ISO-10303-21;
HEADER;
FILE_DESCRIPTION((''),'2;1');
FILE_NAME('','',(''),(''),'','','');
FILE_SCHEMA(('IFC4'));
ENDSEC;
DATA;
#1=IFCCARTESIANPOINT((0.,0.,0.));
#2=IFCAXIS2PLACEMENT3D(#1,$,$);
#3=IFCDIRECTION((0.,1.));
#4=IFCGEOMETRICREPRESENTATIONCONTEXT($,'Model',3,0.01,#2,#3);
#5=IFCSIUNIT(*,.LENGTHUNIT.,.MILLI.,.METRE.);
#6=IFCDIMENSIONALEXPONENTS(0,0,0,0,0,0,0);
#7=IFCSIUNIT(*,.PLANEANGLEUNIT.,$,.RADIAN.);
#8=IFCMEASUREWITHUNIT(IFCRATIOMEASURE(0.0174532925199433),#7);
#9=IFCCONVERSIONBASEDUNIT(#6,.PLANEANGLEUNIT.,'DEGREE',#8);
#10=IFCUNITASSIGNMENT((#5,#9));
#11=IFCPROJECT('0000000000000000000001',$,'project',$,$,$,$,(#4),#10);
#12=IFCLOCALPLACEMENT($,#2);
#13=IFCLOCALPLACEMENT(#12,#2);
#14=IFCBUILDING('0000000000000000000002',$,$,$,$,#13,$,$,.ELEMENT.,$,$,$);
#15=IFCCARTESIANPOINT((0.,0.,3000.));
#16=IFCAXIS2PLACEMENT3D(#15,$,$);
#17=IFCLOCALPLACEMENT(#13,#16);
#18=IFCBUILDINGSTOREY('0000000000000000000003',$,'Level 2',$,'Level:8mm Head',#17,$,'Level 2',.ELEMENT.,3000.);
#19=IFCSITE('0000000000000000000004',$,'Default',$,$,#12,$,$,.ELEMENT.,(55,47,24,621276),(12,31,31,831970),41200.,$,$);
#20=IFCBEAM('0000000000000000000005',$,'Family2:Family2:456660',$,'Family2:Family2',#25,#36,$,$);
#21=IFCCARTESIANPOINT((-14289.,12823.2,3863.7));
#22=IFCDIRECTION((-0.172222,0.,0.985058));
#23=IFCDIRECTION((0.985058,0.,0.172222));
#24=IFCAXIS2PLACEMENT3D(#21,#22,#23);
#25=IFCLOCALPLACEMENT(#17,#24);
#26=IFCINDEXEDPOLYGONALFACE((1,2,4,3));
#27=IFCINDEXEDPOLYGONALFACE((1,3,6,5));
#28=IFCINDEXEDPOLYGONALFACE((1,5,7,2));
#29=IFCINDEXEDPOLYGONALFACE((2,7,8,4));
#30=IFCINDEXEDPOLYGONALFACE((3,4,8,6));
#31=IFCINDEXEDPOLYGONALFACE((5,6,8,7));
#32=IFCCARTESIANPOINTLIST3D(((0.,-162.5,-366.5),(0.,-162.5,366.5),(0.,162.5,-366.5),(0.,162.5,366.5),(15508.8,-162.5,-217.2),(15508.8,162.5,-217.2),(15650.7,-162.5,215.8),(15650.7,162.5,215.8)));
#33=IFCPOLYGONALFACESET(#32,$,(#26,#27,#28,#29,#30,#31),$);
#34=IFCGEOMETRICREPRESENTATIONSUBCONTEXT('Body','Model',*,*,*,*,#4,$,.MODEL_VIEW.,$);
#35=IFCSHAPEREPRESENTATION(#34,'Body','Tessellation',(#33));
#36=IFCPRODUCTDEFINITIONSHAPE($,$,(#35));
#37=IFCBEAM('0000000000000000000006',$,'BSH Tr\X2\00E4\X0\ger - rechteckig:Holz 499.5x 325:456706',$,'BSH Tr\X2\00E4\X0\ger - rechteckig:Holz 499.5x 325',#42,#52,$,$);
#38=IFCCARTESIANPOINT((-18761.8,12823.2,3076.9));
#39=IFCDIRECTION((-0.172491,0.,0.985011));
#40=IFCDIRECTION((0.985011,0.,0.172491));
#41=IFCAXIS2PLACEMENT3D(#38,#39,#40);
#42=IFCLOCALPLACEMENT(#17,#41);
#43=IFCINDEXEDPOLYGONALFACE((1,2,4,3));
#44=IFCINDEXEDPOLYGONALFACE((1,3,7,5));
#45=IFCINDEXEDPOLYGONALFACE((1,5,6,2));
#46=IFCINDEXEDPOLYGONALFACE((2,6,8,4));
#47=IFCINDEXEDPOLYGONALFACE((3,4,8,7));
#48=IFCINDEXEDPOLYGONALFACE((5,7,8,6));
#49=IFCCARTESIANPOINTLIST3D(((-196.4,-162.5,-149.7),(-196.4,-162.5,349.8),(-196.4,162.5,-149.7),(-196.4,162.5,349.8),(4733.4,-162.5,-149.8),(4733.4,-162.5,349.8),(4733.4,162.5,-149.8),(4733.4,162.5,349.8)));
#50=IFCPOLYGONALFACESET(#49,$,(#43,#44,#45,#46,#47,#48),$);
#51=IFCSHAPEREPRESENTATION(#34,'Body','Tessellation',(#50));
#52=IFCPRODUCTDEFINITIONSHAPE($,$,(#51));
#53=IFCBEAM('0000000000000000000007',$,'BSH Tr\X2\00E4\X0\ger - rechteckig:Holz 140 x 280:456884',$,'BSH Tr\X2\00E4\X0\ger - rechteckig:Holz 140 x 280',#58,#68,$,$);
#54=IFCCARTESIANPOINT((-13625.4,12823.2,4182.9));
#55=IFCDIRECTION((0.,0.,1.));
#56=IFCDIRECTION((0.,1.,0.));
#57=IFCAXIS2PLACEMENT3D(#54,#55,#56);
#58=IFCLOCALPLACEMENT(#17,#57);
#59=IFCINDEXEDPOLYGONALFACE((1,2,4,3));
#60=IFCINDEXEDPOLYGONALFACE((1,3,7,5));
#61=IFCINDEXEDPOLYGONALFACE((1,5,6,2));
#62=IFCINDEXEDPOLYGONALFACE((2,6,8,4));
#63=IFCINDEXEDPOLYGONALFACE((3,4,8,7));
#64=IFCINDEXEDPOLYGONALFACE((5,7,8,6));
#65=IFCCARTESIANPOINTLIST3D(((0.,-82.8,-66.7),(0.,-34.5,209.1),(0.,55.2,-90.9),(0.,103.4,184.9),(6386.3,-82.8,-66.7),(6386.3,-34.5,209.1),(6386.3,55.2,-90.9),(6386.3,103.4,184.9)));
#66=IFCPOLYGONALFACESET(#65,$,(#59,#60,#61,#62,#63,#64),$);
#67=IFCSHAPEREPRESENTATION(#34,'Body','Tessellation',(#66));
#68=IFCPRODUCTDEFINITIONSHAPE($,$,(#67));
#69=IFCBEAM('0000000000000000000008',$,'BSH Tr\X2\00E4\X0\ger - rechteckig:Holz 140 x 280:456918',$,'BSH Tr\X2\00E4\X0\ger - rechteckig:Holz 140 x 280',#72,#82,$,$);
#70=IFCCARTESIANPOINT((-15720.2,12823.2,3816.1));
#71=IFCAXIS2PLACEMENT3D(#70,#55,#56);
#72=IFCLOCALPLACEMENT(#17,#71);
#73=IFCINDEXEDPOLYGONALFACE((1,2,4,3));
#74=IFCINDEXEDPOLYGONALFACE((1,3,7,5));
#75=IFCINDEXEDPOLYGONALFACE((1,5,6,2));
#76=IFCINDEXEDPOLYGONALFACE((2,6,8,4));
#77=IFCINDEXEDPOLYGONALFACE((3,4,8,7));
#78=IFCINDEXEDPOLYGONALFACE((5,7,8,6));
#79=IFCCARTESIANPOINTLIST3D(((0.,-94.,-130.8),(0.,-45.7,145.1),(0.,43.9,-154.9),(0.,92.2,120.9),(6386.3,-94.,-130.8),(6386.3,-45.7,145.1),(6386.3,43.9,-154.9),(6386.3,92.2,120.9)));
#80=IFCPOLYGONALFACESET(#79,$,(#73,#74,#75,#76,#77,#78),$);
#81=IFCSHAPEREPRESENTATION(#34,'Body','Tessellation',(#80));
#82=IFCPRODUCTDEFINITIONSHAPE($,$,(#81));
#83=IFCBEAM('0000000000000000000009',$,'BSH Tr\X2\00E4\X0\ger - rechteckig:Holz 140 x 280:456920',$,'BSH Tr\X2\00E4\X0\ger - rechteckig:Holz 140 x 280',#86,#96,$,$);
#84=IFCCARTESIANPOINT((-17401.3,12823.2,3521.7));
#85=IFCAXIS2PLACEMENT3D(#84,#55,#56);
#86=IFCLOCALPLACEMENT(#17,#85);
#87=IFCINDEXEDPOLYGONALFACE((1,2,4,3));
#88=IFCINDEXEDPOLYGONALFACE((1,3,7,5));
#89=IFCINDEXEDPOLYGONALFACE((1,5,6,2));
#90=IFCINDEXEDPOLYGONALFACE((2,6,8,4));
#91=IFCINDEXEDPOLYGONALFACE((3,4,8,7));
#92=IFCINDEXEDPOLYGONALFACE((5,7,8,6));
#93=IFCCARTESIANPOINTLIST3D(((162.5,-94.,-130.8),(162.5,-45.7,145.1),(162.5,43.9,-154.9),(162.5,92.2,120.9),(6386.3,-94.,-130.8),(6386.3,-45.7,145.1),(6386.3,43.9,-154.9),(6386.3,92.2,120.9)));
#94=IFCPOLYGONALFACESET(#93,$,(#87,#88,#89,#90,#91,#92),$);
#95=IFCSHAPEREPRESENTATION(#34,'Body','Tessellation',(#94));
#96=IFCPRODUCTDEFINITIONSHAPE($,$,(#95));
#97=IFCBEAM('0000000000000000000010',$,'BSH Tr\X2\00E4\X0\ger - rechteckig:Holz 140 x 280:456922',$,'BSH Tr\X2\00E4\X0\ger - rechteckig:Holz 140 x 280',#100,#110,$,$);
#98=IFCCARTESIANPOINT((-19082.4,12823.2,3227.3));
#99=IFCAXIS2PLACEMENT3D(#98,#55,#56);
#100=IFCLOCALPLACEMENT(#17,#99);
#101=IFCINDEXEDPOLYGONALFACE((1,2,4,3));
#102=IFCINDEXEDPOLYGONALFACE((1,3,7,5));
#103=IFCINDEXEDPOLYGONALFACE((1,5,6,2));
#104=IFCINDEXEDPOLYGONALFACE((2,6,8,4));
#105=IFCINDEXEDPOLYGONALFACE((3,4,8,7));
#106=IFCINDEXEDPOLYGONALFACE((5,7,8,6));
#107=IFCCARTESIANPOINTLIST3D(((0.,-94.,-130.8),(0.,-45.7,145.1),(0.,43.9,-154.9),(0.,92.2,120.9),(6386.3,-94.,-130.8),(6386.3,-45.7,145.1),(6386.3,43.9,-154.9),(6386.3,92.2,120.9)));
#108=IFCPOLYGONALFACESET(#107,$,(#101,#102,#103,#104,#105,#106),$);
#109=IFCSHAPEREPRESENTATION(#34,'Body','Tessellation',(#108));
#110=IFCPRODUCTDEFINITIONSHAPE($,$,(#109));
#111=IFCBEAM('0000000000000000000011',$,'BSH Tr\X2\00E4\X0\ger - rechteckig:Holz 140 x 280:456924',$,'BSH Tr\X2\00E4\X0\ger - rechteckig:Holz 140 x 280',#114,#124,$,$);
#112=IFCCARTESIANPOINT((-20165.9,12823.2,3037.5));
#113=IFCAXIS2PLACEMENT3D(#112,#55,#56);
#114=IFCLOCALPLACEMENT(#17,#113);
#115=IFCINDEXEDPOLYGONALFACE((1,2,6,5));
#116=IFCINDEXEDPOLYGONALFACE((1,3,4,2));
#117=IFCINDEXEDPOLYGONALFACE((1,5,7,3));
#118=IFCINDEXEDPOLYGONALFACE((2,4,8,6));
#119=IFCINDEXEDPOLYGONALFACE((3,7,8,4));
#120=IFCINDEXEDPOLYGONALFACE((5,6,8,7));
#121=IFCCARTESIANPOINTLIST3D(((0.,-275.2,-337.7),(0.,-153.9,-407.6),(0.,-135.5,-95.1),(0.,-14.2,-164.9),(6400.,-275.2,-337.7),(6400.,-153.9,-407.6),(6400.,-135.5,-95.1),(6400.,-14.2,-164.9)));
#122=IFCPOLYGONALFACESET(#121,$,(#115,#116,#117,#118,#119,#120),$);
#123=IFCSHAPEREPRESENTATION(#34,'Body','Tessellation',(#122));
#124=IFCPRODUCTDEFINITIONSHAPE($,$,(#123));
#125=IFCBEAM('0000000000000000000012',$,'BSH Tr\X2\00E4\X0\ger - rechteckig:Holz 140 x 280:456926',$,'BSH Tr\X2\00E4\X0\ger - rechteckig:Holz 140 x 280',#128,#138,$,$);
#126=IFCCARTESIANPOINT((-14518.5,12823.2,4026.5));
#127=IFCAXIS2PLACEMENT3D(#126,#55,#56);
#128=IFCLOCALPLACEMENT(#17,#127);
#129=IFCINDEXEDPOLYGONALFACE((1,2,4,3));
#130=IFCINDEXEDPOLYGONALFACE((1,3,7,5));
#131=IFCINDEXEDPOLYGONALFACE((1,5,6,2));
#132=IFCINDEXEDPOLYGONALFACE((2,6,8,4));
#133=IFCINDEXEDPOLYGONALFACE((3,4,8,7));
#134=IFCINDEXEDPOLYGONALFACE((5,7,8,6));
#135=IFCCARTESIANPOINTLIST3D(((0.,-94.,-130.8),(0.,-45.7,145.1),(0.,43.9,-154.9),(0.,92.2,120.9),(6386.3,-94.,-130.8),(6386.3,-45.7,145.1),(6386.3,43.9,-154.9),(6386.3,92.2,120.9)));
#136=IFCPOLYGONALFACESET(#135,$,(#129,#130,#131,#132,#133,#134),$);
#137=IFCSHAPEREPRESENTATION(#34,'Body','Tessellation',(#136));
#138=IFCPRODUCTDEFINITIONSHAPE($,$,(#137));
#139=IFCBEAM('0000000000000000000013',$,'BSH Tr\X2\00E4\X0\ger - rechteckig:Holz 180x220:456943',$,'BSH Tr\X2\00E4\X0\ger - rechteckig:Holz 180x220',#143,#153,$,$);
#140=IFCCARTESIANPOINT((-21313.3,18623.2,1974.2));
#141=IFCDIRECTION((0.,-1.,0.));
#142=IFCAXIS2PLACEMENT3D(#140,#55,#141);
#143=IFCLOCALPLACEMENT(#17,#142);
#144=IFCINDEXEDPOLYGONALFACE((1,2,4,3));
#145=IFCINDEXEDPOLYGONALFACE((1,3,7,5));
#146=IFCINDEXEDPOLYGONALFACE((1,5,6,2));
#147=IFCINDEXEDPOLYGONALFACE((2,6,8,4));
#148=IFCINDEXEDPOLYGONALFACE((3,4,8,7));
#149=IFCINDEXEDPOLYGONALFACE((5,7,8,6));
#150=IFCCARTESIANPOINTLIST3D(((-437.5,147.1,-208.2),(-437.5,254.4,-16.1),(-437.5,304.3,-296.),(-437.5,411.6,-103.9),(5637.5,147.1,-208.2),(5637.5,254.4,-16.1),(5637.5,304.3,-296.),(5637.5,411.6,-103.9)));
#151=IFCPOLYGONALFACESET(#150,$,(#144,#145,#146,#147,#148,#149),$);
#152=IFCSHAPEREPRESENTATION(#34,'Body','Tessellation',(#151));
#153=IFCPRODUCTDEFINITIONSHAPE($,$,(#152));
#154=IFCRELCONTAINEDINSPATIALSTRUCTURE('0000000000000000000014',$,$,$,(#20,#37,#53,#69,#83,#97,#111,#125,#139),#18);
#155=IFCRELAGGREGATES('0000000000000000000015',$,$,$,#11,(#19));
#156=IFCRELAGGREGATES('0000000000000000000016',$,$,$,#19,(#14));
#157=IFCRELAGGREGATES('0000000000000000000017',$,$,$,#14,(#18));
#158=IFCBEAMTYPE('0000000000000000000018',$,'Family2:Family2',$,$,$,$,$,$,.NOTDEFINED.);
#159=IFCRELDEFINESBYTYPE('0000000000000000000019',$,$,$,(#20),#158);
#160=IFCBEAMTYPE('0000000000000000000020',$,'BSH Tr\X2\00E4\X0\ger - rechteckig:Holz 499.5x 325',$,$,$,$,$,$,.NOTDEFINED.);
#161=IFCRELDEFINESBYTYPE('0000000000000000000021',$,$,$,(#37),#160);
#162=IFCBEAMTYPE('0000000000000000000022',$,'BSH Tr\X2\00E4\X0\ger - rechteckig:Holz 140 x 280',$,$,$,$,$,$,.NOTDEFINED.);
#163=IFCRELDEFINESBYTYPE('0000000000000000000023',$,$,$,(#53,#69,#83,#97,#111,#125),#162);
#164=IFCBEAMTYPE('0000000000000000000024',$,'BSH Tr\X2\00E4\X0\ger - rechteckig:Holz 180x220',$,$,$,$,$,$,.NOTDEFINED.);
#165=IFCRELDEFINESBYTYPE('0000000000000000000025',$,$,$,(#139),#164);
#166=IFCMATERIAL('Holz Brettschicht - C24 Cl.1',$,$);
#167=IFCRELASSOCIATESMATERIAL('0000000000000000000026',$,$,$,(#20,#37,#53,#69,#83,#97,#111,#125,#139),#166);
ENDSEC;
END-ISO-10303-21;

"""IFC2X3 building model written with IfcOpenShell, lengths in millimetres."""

from ifc_helpers import new_model, entity, si_unit, converted_unit, direction, frame, frame_2d, origin, origin_2d_with_axis, place, context, subcontext, project, spatial, polyline, rectangle, extrude, clip, bounded_halfspace, material, type_object, element, save


model = new_model("IFC2X3")

# Units and contexts
model_context = context("Model", 3, precision=0.01, world=origin(), true_north=direction((0.0, 1.0)))
body_context = subcontext(model_context, "Body", "Model", "MODEL_VIEW")
ifc_project = project(units=[si_unit("LENGTHUNIT", "METRE", prefix="MILLI"), converted_unit("PLANEANGLEUNIT", "DEGREE", entity("IfcRatioMeasure", 0.0174532925199433), si_unit("PLANEANGLEUNIT", "RADIAN"), dimensions=[0, 0, 0, 0, 0, 0, 0])], contexts=[model_context])

# Site, building, storey
site_placement = place(None, origin())
site = spatial("IfcSite", under=ifc_project, at=site_placement, Name="Default", CompositionType="ELEMENT", RefLatitude=(55, 47, 24, 621276), RefLongitude=(12, 31, 31, 831970), RefElevation=41200.0)
building_placement = place(site_placement, origin())
building = spatial("IfcBuilding", under=site, at=building_placement, CompositionType="ELEMENT")
storey_placement = place(building_placement, frame((0.0, 0.0, 3000.0)))
storey = spatial("IfcBuildingStorey", under=building, at=storey_placement, Name="Level 2", ObjectType="Level:8mm Head", LongName="Level 2", CompositionType="ELEMENT", Elevation=3000.0)

# Beams
ifc_material = material(Name="Holz Brettschicht - C24 Cl.1")
beam_type_1 = type_object("IfcBeamType", Name="Family2:Family2", PredefinedType="NOTDEFINED")
beam_1_placement = place(storey_placement, frame((-14289.0, 12823.2, 3863.7), z_axis=(-0.172222, 0.0, 0.985058), x_axis=(0.985058, 0.0, 0.172222)))
element("IfcBeam", 1, at=beam_1_placement, inside=storey, type_object=beam_type_1, material=ifc_material, Name="Family2:Family2:456660", ObjectType="Family2:Family2", context=body_context, shape_type="Clipping", body=[
    clip(clip(clip(extrude(rectangle(XDim=733.0, YDim=325.0, at=frame_2d((0.0, 0.0), x_axis=(0.0, 1.0))), frame((0.0, 0.0, 0.0), z_axis=(1.0, 0.0, 0.0), x_axis=(0.0, 1.0, 0.0)), (0.0, 0.0, 1.0), 15650.7), bounded_halfspace(frame((0.0, 0.0, -366.5), z_axis=(0.009627, 0.0, -0.999954), x_axis=(0.0, 1.0, 0.0)), False, frame((0.0, 0.0, 0.0), z_axis=(1.0, 0.0, 0.0), x_axis=(0.0, 1.0, 0.0)), polyline([(-162.5, -366.5), (162.5, -366.5), (162.5, -217.2), (-162.5, -217.2), (-162.5, -366.5)]))), bounded_halfspace(frame((15700.1, 0.0, 366.5), z_axis=(0.95028, 0.0, -0.311395), x_axis=(0.311395, 0.0, 0.95028)), False, frame((0.0, 0.0, 0.0), z_axis=(1.0, 0.0, 0.0), x_axis=(0.0, 1.0, 0.0)), polyline([(-162.5, 215.8), (-162.5, -217.2), (162.5, -217.2), (162.5, 215.8), (-162.5, 215.8)]))), bounded_halfspace(frame((0.0, 0.0, 366.5), z_axis=(0.009627, 0.0, 0.999954), x_axis=(0.0, -1.0, 0.0)), False, frame((0.0, 0.0, 0.0), z_axis=(1.0, 0.0, 0.0), x_axis=(0.0, 1.0, 0.0)), polyline([(162.5, 366.5), (-162.5, 366.5), (-162.5, 215.8), (162.5, 215.8), (162.5, 366.5)]))),
])
beam_type_2 = type_object("IfcBeamType", Name="BSH Träger - rechteckig:Holz 499.5x 325", PredefinedType="NOTDEFINED")
beam_2_placement = place(storey_placement, frame((-18761.8, 12823.2, 3076.9), z_axis=(-0.172491, 0.0, 0.985011), x_axis=(0.985011, 0.0, 0.172491)))
element("IfcBeam", 2, at=beam_2_placement, inside=storey, type_object=beam_type_2, material=ifc_material, Name="BSH Träger - rechteckig:Holz 499.5x 325:456706", ObjectType="BSH Träger - rechteckig:Holz 499.5x 325", context=body_context, shape_type="SweptSolid", body=[
    extrude(rectangle(XDim=499.5, YDim=325.0, at=origin_2d_with_axis()), frame((-196.4, 0.0, 100.0), z_axis=(1.0, 0.0, 0.0), x_axis=(0.0, 0.0, -1.0)), (0.0, 0.0, 1.0), 4929.8),
])
beam_type_3 = type_object("IfcBeamType", Name="BSH Träger - rechteckig:Holz 140 x 280", PredefinedType="NOTDEFINED")
beam_3_placement = place(storey_placement, frame((-13625.4, 12823.2, 4182.9), z_axis=(0.0, 0.0, 1.0), x_axis=(0.0, 1.0, 0.0)))
element("IfcBeam", 3, at=beam_3_placement, inside=storey, type_object=beam_type_3, material=ifc_material, Name="BSH Träger - rechteckig:Holz 140 x 280:456884", ObjectType="BSH Träger - rechteckig:Holz 140 x 280", context=body_context, shape_type="SweptSolid", body=[
    extrude(rectangle(XDim=280.0, YDim=140.0, at=origin_2d_with_axis()), frame((0.0, 10.3, 59.1), z_axis=(1.0, 0.0, 0.0), x_axis=(0.0, 0.172491, 0.985011)), (0.0, 0.0, 1.0), 6386.3),
])
beam_4_placement = place(storey_placement, frame((-15720.2, 12823.2, 3816.1), z_axis=(0.0, 0.0, 1.0), x_axis=(0.0, 1.0, 0.0)))
element("IfcBeam", 4, at=beam_4_placement, inside=storey, type_object=beam_type_3, material=ifc_material, Name="BSH Träger - rechteckig:Holz 140 x 280:456918", ObjectType="BSH Träger - rechteckig:Holz 140 x 280", context=body_context, shape_type="SweptSolid", body=[
    extrude(rectangle(XDim=280.0, YDim=140.0, at=origin_2d_with_axis()), frame((0.0, -0.9, -4.9), z_axis=(1.0, 0.0, 0.0), x_axis=(0.0, 0.172491, 0.985011)), (0.0, 0.0, 1.0), 6386.3),
])
beam_5_placement = place(storey_placement, frame((-17401.3, 12823.2, 3521.7), z_axis=(0.0, 0.0, 1.0), x_axis=(0.0, 1.0, 0.0)))
element("IfcBeam", 5, at=beam_5_placement, inside=storey, type_object=beam_type_3, material=ifc_material, Name="BSH Träger - rechteckig:Holz 140 x 280:456920", ObjectType="BSH Träger - rechteckig:Holz 140 x 280", context=body_context, shape_type="SweptSolid", body=[
    extrude(rectangle(XDim=280.0, YDim=140.0, at=origin_2d_with_axis()), frame((162.5, -0.9, -4.9), z_axis=(1.0, 0.0, 0.0), x_axis=(0.0, 0.172491, 0.985011)), (0.0, 0.0, 1.0), 6223.8),
])
beam_6_placement = place(storey_placement, frame((-19082.4, 12823.2, 3227.3), z_axis=(0.0, 0.0, 1.0), x_axis=(0.0, 1.0, 0.0)))
element("IfcBeam", 6, at=beam_6_placement, inside=storey, type_object=beam_type_3, material=ifc_material, Name="BSH Träger - rechteckig:Holz 140 x 280:456922", ObjectType="BSH Träger - rechteckig:Holz 140 x 280", context=body_context, shape_type="SweptSolid", body=[
    extrude(rectangle(XDim=280.0, YDim=140.0, at=origin_2d_with_axis()), frame((0.0, -0.9, -4.9), z_axis=(1.0, 0.0, 0.0), x_axis=(0.0, 0.172491, 0.985011)), (0.0, 0.0, 1.0), 6386.3),
])
beam_7_placement = place(storey_placement, frame((-20165.9, 12823.2, 3037.5), z_axis=(0.0, 0.0, 1.0), x_axis=(0.0, 1.0, 0.0)))
element("IfcBeam", 7, at=beam_7_placement, inside=storey, type_object=beam_type_3, material=ifc_material, Name="BSH Träger - rechteckig:Holz 140 x 280:456924", ObjectType="BSH Träger - rechteckig:Holz 140 x 280", context=body_context, shape_type="SweptSolid", body=[
    extrude(rectangle(XDim=280.0, YDim=140.0, at=origin_2d_with_axis()), frame((0.0, -144.7, -251.3), z_axis=(1.0, 0.0, 0.0), x_axis=(0.0, 0.498982, 0.866612)), (0.0, 0.0, 1.0), 6400.0),
])
beam_8_placement = place(storey_placement, frame((-14518.5, 12823.2, 4026.5), z_axis=(0.0, 0.0, 1.0), x_axis=(0.0, 1.0, 0.0)))
element("IfcBeam", 8, at=beam_8_placement, inside=storey, type_object=beam_type_3, material=ifc_material, Name="BSH Träger - rechteckig:Holz 140 x 280:456926", ObjectType="BSH Träger - rechteckig:Holz 140 x 280", context=body_context, shape_type="SweptSolid", body=[
    extrude(rectangle(XDim=280.0, YDim=140.0, at=origin_2d_with_axis()), frame((0.0, -0.9, -4.9), z_axis=(1.0, 0.0, 0.0), x_axis=(0.0, 0.172491, 0.985011)), (0.0, 0.0, 1.0), 6386.3),
])
beam_type_4 = type_object("IfcBeamType", Name="BSH Träger - rechteckig:Holz 180x220", PredefinedType="NOTDEFINED")
beam_9_placement = place(storey_placement, frame((-21313.3, 18623.2, 1974.2), z_axis=(0.0, 0.0, 1.0), x_axis=(0.0, -1.0, 0.0)))
element("IfcBeam", 9, at=beam_9_placement, inside=storey, type_object=beam_type_4, material=ifc_material, Name="BSH Träger - rechteckig:Holz 180x220:456943", ObjectType="BSH Träger - rechteckig:Holz 180x220", context=body_context, shape_type="SweptSolid", body=[
    extrude(rectangle(XDim=220.0, YDim=180.0, at=frame_2d((0.0, 0.0), x_axis=(1.0, 0.0))), frame((-437.5, 279.4, -156.1), z_axis=(1.0, 0.0, 0.0), x_axis=(0.0, 0.4877, 0.873011)), (0.0, 0.0, 1.0), 6075.0),
])

save(model, "model.ifc")
